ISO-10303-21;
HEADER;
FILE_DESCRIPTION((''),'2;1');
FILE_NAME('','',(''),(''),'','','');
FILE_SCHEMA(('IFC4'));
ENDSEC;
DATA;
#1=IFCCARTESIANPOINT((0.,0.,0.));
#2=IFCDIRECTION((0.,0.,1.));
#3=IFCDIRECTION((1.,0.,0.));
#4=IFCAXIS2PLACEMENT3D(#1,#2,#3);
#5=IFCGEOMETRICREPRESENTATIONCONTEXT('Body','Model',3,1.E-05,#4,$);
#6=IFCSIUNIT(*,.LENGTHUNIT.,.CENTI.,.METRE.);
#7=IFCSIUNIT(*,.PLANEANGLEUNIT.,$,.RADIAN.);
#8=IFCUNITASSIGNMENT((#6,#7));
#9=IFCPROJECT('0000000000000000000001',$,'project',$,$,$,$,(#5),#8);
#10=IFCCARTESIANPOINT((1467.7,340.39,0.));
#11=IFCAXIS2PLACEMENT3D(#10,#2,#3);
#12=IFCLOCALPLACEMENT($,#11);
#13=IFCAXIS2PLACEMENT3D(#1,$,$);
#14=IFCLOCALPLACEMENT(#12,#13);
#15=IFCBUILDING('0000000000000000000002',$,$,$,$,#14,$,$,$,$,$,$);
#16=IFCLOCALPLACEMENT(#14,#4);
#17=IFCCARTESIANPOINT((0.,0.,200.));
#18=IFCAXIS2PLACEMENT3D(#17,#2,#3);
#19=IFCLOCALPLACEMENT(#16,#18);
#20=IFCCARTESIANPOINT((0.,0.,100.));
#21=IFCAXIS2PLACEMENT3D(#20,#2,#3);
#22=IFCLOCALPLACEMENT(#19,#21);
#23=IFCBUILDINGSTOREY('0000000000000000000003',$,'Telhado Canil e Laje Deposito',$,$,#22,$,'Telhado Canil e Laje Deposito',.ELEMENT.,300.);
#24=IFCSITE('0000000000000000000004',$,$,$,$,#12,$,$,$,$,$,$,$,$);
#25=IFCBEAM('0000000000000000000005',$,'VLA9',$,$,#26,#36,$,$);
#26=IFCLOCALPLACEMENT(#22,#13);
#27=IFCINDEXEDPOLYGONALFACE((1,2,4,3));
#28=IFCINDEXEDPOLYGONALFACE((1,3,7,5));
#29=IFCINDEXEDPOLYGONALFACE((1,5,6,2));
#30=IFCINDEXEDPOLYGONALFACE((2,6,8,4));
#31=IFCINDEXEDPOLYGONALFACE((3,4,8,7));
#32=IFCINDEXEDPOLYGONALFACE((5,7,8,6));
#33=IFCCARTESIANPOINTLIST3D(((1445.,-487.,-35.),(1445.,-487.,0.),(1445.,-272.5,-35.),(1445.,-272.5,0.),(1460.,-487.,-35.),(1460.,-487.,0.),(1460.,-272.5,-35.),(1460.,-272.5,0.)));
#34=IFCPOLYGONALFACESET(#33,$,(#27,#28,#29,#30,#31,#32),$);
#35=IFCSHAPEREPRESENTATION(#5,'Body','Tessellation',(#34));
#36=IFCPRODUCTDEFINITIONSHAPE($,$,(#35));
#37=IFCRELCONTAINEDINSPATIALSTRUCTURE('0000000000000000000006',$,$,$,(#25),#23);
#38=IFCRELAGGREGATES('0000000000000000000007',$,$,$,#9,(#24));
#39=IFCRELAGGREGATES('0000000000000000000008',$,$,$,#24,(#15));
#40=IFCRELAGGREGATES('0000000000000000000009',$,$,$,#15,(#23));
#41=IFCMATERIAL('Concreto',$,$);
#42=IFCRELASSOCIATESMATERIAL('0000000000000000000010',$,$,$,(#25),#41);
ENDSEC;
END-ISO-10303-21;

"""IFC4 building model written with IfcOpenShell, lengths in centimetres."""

from ifc_helpers import new_model, si_unit, frame, origin, origin_with_axes, origin_2d_with_axis, place, context, project, spatial, rectangle, extrude, material, element, save


model = new_model("IFC4")

# Units and contexts
model_context = context("Model", 3, precision=1e-05, world=origin_with_axes(), identifier="Body")
ifc_project = project(units=[si_unit("LENGTHUNIT", "METRE", prefix="CENTI"), si_unit("PLANEANGLEUNIT", "RADIAN")], contexts=[model_context])

# Site, building, storey
site_placement = place(None, frame((1467.7, 340.39, 0.0), z_axis=(0.0, 0.0, 1.0), x_axis=(1.0, 0.0, 0.0)))
site = spatial("IfcSite", under=ifc_project, at=site_placement)
building_placement = place(site_placement, origin())
building = spatial("IfcBuilding", under=site, at=building_placement)
placement_1 = place(building_placement, origin_with_axes())
placement_2 = place(placement_1, frame((0.0, 0.0, 200.0), z_axis=(0.0, 0.0, 1.0), x_axis=(1.0, 0.0, 0.0)))
storey_placement = place(placement_2, frame((0.0, 0.0, 100.0), z_axis=(0.0, 0.0, 1.0), x_axis=(1.0, 0.0, 0.0)))
storey = spatial("IfcBuildingStorey", under=building, at=storey_placement, Name="Telhado Canil e Laje Deposito", LongName="Telhado Canil e Laje Deposito", CompositionType="ELEMENT", Elevation=300.0)

# Shared definitions
ifc_material = material(Name="Concreto")

# Beam
for number, where, z_axis, x_axis, name in (
    (1, (1452.5, -379.75, 0.0), (0.0, 0.0, 1.0), (1.0, 0.0, 0.0), "VLA9"),
):
    element("IfcBeam", number, at=place(storey_placement, frame(where, z_axis=z_axis, x_axis=x_axis)), inside=storey, material=ifc_material, Name=name, context=model_context, shape_type="SolidModel", body=[
        extrude(rectangle(XDim=15.0, YDim=35.0, at=origin_2d_with_axis()), frame((0.0, -107.25, -17.5), z_axis=(0.0, 1.0, 0.0), x_axis=(1.0, 0.0, 0.0)), (0.0, 0.0, 1.0), 214.5),
    ])

save(model, "model.ifc")
